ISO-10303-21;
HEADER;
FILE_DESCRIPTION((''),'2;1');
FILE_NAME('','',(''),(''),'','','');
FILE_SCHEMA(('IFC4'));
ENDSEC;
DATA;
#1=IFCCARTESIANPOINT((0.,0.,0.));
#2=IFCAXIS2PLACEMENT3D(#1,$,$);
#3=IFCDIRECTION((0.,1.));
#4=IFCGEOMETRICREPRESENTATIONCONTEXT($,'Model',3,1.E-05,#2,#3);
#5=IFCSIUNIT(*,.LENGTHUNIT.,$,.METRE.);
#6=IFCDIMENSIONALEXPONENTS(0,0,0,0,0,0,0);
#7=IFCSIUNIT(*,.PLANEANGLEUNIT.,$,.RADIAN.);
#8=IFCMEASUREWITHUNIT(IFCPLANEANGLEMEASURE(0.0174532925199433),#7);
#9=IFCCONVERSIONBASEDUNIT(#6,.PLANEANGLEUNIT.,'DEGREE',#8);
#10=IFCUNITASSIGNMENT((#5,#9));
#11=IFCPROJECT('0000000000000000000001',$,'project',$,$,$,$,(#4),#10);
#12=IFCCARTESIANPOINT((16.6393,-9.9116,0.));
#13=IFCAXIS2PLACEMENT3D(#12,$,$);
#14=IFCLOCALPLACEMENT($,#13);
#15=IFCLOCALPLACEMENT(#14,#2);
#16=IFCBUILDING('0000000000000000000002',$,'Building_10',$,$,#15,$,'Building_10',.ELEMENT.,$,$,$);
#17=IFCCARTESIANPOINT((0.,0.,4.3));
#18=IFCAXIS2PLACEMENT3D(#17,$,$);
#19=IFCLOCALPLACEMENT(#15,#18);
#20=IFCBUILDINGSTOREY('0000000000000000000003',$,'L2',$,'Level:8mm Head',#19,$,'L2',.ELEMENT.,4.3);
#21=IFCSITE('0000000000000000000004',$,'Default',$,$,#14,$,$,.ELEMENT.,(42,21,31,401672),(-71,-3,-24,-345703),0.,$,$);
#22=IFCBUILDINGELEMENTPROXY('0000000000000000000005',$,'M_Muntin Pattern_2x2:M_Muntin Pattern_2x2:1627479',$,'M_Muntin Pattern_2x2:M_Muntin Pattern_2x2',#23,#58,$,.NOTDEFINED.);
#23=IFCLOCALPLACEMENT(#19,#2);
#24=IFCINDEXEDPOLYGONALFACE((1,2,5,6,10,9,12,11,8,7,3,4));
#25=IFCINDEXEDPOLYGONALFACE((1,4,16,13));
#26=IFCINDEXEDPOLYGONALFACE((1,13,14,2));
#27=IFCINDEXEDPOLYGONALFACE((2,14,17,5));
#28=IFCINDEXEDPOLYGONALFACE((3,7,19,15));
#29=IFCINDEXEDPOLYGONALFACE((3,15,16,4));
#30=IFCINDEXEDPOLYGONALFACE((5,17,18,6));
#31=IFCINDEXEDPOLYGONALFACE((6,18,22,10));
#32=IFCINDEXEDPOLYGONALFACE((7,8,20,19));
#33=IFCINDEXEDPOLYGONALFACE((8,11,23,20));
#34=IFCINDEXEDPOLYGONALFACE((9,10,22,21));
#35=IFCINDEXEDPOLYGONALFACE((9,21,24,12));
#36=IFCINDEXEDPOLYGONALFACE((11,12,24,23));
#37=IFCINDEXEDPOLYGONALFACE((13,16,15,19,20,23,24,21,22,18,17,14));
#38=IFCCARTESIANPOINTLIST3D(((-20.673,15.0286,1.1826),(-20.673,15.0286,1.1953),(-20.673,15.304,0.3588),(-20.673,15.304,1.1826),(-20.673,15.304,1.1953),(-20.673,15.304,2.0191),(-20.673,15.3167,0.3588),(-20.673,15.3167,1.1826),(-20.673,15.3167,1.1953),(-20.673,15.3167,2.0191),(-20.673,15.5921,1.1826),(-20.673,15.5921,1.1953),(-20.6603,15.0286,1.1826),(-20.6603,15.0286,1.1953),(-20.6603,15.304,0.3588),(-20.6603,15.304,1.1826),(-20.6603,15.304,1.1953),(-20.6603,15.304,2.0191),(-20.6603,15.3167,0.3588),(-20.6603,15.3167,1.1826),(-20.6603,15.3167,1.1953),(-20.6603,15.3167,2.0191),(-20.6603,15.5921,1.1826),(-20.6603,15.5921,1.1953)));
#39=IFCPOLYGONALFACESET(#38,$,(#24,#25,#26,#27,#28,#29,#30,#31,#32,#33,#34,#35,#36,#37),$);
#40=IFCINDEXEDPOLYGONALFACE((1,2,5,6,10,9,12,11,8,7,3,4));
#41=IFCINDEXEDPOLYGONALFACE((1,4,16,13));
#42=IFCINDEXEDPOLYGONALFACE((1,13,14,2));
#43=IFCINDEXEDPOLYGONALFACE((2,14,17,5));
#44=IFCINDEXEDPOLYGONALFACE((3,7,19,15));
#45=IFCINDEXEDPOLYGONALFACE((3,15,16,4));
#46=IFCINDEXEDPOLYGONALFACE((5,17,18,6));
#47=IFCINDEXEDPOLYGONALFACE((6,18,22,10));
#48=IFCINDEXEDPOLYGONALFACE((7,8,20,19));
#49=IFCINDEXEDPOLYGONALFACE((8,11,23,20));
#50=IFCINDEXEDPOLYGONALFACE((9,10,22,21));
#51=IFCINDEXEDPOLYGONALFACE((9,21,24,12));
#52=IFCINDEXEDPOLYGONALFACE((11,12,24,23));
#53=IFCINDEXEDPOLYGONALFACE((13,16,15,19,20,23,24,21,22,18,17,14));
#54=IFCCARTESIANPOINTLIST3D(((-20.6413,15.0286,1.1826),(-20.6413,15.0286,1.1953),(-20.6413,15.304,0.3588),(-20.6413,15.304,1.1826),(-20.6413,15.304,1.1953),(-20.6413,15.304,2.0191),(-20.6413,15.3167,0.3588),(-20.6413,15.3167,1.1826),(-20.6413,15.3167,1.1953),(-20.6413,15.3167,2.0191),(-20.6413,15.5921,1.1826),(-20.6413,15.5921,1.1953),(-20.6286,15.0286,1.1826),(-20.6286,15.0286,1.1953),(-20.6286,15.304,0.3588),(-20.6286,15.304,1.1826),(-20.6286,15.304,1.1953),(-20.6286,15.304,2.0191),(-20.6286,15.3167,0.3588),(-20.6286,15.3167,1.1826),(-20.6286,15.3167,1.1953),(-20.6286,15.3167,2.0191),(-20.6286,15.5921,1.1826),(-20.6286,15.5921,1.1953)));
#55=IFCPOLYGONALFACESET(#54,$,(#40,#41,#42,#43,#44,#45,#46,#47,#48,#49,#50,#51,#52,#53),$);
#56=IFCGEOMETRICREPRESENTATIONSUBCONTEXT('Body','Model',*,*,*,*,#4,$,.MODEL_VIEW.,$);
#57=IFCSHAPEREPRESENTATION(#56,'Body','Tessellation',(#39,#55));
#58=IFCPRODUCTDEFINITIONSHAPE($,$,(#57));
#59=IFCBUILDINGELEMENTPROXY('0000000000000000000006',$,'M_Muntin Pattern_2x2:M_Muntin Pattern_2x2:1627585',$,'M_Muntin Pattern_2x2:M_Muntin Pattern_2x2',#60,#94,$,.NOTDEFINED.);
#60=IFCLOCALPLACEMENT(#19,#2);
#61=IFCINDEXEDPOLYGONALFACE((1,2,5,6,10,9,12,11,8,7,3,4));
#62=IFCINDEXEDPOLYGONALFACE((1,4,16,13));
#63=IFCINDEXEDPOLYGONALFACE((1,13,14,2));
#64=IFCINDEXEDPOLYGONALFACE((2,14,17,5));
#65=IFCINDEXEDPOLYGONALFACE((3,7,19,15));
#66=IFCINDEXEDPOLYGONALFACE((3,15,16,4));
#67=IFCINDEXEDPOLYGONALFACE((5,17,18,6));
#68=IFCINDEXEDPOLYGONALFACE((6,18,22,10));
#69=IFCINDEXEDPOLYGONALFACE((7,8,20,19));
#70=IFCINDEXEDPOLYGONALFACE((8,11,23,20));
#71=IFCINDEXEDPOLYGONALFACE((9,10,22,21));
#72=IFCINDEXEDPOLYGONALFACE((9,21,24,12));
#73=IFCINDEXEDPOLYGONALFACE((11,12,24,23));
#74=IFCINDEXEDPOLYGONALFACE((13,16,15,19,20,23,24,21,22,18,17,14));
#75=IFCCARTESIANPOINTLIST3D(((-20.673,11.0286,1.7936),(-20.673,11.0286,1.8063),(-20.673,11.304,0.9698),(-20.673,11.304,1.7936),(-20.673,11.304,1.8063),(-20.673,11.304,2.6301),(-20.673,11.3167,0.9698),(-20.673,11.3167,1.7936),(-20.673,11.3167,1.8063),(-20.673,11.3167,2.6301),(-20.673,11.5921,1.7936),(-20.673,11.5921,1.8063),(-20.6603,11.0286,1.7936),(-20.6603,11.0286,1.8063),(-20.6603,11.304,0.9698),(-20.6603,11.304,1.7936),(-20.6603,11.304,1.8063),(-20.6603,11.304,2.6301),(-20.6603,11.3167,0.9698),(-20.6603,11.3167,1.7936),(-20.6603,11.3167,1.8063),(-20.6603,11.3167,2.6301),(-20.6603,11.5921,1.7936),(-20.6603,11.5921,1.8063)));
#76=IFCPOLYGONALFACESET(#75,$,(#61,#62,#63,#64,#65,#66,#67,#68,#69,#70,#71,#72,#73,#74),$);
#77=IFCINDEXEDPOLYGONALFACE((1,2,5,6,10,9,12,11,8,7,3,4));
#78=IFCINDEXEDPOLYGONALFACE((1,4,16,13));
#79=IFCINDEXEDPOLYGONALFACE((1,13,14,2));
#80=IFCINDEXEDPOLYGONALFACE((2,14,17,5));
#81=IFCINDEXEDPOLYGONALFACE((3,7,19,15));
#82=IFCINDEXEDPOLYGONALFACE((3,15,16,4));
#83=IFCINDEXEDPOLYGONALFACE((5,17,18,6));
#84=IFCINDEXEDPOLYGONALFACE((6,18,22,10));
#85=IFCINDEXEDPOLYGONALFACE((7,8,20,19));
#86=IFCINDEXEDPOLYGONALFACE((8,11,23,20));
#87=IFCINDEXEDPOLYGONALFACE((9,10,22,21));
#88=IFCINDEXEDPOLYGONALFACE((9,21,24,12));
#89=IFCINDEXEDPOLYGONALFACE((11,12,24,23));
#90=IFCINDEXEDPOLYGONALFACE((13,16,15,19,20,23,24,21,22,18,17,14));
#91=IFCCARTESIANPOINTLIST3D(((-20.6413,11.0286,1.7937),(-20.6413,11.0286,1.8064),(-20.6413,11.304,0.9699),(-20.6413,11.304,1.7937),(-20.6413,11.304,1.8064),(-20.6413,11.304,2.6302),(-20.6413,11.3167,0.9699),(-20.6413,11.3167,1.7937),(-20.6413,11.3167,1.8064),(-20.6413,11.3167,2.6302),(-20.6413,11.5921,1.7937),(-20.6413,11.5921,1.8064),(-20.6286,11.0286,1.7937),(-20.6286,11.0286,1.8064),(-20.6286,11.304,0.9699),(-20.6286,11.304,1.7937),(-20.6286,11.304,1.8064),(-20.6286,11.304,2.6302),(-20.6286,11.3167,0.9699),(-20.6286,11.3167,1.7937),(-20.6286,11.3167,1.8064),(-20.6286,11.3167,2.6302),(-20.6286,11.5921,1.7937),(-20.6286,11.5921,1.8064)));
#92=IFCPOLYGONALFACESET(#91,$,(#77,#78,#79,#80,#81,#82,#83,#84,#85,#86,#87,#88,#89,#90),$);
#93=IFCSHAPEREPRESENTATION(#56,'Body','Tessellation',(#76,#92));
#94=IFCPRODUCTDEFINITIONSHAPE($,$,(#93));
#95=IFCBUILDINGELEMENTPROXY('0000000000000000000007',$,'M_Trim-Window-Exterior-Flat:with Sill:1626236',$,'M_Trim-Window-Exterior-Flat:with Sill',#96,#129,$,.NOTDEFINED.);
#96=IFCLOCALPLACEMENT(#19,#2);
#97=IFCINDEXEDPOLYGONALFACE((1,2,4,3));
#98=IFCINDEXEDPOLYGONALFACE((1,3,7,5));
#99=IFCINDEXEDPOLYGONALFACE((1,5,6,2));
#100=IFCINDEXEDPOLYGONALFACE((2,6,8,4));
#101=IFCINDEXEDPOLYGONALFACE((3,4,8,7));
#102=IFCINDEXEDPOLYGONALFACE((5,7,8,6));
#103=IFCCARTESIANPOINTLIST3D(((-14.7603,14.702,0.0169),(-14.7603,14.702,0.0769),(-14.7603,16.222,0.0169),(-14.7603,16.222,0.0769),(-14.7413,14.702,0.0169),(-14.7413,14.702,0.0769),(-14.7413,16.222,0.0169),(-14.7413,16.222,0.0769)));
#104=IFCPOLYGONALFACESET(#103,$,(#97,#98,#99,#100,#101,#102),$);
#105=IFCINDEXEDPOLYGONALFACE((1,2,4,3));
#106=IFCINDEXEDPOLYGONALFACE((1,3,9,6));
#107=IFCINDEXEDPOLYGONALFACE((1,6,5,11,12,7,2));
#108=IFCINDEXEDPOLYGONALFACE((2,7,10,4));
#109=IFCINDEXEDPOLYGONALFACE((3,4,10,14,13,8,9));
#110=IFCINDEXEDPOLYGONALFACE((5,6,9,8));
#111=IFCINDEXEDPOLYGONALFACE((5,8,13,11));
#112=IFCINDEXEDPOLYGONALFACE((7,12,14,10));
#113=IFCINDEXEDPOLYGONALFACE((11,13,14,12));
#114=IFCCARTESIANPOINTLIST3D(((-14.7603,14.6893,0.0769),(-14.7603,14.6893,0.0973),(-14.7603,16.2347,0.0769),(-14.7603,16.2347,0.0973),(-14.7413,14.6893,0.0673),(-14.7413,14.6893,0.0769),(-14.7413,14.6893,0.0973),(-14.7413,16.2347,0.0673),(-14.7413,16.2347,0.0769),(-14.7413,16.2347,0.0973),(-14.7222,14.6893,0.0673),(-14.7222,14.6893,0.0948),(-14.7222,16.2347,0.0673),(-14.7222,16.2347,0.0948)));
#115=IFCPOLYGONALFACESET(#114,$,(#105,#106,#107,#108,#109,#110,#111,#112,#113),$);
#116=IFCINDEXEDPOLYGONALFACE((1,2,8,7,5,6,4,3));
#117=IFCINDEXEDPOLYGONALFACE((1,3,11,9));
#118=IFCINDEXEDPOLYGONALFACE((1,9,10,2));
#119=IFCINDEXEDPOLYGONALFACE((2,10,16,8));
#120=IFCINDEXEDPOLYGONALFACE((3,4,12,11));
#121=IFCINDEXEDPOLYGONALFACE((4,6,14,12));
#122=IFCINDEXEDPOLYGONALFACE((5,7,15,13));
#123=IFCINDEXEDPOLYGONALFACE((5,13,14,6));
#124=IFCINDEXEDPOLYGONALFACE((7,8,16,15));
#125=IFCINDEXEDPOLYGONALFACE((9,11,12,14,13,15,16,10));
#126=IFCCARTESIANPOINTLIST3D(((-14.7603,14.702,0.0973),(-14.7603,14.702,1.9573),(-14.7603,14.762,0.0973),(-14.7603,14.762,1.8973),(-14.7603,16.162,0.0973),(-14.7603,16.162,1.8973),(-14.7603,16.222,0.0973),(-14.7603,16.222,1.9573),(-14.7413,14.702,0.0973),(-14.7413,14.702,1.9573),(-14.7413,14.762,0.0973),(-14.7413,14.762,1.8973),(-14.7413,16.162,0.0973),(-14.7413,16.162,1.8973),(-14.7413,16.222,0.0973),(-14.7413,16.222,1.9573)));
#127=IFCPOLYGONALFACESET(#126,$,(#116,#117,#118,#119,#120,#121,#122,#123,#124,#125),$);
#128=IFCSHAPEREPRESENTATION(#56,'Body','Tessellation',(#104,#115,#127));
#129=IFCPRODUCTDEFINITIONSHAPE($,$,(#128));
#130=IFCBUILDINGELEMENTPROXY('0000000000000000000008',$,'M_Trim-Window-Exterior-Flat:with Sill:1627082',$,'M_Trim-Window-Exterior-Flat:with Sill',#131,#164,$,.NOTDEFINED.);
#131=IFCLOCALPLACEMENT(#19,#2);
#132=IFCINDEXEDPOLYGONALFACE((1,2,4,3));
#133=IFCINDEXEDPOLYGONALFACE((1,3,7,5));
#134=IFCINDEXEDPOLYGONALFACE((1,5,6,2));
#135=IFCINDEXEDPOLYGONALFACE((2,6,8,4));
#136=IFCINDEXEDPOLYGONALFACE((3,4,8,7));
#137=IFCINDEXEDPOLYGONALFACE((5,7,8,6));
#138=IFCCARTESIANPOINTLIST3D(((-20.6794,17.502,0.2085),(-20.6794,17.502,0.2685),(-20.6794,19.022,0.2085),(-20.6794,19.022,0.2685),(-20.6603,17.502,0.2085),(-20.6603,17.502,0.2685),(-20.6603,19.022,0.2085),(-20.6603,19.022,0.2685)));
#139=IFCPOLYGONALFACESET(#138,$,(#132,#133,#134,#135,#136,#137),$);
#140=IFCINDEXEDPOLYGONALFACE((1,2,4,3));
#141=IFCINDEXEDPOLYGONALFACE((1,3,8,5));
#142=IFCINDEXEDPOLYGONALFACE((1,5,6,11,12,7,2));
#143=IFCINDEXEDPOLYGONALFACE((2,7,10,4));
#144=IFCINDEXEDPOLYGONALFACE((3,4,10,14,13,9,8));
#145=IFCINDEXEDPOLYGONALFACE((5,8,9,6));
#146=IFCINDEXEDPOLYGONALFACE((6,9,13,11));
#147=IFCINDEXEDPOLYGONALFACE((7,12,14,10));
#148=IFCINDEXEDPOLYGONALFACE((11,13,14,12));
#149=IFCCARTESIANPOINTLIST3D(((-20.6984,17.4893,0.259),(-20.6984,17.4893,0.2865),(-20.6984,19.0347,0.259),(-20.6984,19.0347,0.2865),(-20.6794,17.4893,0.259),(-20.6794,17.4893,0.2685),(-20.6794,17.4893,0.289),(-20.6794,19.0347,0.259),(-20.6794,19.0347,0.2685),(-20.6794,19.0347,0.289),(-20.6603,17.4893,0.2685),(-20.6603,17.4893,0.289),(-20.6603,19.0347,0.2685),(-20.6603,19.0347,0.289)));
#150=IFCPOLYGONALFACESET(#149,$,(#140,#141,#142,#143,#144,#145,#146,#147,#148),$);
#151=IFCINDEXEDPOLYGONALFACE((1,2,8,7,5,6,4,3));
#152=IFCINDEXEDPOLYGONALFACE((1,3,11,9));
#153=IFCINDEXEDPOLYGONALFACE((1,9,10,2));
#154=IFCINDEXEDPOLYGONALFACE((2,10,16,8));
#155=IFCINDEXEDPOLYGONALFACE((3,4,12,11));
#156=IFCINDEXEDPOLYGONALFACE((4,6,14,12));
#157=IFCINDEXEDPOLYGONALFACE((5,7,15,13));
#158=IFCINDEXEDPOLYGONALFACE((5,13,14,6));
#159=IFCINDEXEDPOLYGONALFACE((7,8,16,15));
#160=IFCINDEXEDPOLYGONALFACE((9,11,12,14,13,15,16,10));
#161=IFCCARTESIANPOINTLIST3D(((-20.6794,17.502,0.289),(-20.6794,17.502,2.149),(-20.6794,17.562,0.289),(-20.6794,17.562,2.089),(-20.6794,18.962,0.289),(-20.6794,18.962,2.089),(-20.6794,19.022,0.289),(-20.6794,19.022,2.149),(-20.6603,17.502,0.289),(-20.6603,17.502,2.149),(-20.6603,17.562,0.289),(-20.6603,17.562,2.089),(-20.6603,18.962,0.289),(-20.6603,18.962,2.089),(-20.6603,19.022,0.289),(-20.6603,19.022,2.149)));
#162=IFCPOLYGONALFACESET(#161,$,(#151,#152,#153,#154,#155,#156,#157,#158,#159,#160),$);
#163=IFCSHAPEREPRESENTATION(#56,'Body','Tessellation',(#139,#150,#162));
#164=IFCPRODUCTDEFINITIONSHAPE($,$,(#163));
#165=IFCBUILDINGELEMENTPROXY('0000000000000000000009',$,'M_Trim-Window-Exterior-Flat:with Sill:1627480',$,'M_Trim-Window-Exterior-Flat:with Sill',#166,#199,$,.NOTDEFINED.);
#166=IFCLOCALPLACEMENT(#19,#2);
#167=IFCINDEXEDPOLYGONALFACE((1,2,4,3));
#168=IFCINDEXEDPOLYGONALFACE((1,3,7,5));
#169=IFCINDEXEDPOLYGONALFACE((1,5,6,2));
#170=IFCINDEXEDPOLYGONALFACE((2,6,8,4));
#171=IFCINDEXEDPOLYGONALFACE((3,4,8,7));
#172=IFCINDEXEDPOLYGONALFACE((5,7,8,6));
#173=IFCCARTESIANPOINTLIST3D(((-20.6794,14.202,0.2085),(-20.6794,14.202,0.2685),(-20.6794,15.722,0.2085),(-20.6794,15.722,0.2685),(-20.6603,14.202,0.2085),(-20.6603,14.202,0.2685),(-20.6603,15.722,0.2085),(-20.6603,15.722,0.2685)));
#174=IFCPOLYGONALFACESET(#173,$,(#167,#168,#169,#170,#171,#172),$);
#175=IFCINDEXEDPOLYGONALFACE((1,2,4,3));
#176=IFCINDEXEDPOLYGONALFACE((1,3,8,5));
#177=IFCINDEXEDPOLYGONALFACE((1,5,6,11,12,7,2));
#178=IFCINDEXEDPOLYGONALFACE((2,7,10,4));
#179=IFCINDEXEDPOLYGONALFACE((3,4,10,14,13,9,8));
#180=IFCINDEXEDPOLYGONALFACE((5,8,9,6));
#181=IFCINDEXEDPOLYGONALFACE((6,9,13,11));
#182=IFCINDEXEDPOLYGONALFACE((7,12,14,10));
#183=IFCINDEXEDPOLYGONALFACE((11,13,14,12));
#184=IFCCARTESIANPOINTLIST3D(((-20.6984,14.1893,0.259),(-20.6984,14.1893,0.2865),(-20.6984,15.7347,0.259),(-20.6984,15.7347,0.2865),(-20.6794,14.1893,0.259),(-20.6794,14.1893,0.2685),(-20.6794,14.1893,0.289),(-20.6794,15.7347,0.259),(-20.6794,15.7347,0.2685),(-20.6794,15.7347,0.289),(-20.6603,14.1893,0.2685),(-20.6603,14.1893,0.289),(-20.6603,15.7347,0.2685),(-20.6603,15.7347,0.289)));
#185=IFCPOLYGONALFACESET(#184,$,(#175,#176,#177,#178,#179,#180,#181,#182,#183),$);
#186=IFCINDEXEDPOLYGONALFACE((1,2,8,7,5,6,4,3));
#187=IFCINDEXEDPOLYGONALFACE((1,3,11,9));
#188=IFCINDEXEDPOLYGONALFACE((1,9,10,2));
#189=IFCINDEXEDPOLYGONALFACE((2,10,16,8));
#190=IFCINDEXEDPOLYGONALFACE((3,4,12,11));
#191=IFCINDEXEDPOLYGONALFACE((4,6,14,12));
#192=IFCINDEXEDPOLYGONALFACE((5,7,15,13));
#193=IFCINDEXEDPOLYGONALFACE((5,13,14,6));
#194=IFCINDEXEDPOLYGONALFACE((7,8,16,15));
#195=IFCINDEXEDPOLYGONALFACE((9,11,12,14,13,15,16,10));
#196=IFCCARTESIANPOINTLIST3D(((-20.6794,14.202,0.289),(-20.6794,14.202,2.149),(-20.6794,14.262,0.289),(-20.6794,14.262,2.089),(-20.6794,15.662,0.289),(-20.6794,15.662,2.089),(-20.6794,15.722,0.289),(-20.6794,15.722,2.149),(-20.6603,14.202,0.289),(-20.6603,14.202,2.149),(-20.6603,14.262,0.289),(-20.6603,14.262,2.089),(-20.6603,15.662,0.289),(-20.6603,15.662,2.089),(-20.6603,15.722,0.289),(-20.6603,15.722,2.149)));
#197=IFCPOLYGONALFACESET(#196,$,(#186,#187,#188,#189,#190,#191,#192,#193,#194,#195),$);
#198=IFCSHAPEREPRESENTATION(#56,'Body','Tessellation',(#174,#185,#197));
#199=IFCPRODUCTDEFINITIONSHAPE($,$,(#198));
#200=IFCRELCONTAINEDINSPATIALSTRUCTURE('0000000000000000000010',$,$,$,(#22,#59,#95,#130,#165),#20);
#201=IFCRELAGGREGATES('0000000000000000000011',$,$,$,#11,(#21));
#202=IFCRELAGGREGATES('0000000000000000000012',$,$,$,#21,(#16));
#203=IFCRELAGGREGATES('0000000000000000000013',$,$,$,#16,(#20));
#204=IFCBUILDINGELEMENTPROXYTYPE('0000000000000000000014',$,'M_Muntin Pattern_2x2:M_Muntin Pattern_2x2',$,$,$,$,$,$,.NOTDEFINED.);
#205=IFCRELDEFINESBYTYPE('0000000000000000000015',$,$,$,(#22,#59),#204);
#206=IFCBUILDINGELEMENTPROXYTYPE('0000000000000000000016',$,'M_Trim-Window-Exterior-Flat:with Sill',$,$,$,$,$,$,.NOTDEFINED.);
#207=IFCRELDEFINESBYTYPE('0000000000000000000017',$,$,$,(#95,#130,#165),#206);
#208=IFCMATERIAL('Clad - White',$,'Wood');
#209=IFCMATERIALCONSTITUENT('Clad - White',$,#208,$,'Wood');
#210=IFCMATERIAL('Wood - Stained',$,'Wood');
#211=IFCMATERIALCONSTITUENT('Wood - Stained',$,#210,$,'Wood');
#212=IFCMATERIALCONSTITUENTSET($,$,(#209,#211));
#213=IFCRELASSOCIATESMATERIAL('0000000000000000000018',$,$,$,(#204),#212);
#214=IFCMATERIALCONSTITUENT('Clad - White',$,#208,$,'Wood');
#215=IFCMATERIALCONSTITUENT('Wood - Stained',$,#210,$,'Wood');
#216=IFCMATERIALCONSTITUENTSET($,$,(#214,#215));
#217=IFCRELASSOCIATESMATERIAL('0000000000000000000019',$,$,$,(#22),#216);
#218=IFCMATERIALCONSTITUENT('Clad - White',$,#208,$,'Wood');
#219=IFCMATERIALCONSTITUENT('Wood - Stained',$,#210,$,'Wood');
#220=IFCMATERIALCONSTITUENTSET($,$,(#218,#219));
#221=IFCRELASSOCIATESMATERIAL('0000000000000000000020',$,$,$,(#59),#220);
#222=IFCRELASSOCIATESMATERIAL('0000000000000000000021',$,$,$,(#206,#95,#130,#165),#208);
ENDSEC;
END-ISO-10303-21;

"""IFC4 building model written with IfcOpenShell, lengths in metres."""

from ifc_helpers import new_model, entity, si_unit, converted_unit, direction, frame, origin, place, context, subcontext, project, spatial, indexed_curve, outline, extrude, source, transform, mapped, material, constituent, constituent_set, type_object, type_shapes, element, save


model = new_model("IFC4")

# Units and contexts
model_context = context("Model", 3, precision=1e-05, world=origin(), true_north=direction((0.0, 1.0)))
body_context = subcontext(model_context, "Body", "Model", "MODEL_VIEW")
ifc_project = project(units=[si_unit("LENGTHUNIT", "METRE"), converted_unit("PLANEANGLEUNIT", "DEGREE", entity("IfcPlaneAngleMeasure", 0.0174532925199433), si_unit("PLANEANGLEUNIT", "RADIAN"), dimensions=[0, 0, 0, 0, 0, 0, 0])], contexts=[model_context])

# Site, building, storey
site_placement = place(None, frame((16.6393, -9.9116, 0.0)))
site = spatial("IfcSite", under=ifc_project, at=site_placement, Name="Default", CompositionType="ELEMENT", RefLatitude=(42, 21, 31, 401672), RefLongitude=(-71, -3, -24, -345703), RefElevation=0.0)
building_placement = place(site_placement, origin())
building = spatial("IfcBuilding", under=site, at=building_placement, Name="Building_10", LongName="Building_10", CompositionType="ELEMENT")
storey_placement = place(building_placement, frame((0.0, 0.0, 4.3)))
storey = spatial("IfcBuildingStorey", under=building, at=storey_placement, Name="L2", ObjectType="Level:8mm Head", LongName="L2", CompositionType="ELEMENT", Elevation=4.3)

# Building element proxies
ifc_material_1 = material(Name="Clad - White", Category="Wood")
ifc_material_2 = material(Name="Wood - Stained", Category="Wood")
ifc_constituent_1 = constituent(ifc_material_1, Name="Clad - White", Category="Wood")
ifc_constituent_2 = constituent(ifc_material_2, Name="Wood - Stained", Category="Wood")
ifc_constituent_set_1 = constituent_set(constituents=[ifc_constituent_1, ifc_constituent_2])
building_element_proxy_type_1 = type_object("IfcBuildingElementProxyType", Name="M_Muntin Pattern_2x2:M_Muntin Pattern_2x2", PredefinedType="NOTDEFINED", material=ifc_constituent_set_1)
shared_shape_1 = source(origin(), body_context, "Body", "SweptSolid", [
    extrude(outline(indexed_curve([(0.0064, -0.0064), (0.8301, -0.0064), (0.8301, 0.0063), (0.0064, 0.0063), (0.0064, 0.2817), (-0.0063, 0.2817), (-0.0063, 0.0063), (-0.8302, 0.0063), (-0.8302, -0.0064), (-0.0063, -0.0064), (-0.0063, -0.2817), (0.0064, -0.2817), (0.0064, -0.0064)], self_intersect=False)), frame((0.0, -0.0222, 0.8301), z_axis=(0.0, 1.0, 0.0), x_axis=(0.0, 0.0, 1.0)), (0.0, 0.0, 1.0), 0.0127),
    extrude(outline(indexed_curve([(0.0064, -0.0064), (0.8302, -0.0064), (0.8302, 0.0063), (0.0064, 0.0063), (0.0064, 0.2817), (-0.0063, 0.2817), (-0.0063, 0.0063), (-0.8302, 0.0063), (-0.8302, -0.0064), (-0.0063, -0.0064), (-0.0063, -0.2817), (0.0064, -0.2817), (0.0064, -0.0064)], self_intersect=False)), frame((0.0, 0.0095, 0.8302), z_axis=(0.0, 1.0, 0.0), x_axis=(0.0, 0.0, 1.0)), (0.0, 0.0, 1.0), 0.0127),
])
type_shapes(building_element_proxy_type_1, [shared_shape_1])
ifc_constituent_3 = constituent(ifc_material_1, Name="Clad - White", Category="Wood")
ifc_constituent_4 = constituent(ifc_material_2, Name="Wood - Stained", Category="Wood")
ifc_constituent_set_2 = constituent_set(constituents=[ifc_constituent_3, ifc_constituent_4])
proxy_1_placement = place(storey_placement, frame((-20.6508, 15.3104, 0.3588), z_axis=(0.0, 0.0, 1.0), x_axis=(0.0, -1.0, 0.0)))
element("IfcBuildingElementProxy", 1, at=proxy_1_placement, inside=storey, type_object=building_element_proxy_type_1, material=ifc_constituent_set_2, Name="M_Muntin Pattern_2x2:M_Muntin Pattern_2x2:1627479", ObjectType="M_Muntin Pattern_2x2:M_Muntin Pattern_2x2", PredefinedType="NOTDEFINED", context=body_context, shape_type="MappedRepresentation", body=[
    mapped(shared_shape_1, transform((0.0, 0.0, 0.0), scale=1.0)),
])
ifc_constituent_5 = constituent(ifc_material_1, Name="Clad - White", Category="Wood")
ifc_constituent_6 = constituent(ifc_material_2, Name="Wood - Stained", Category="Wood")
ifc_constituent_set_3 = constituent_set(constituents=[ifc_constituent_5, ifc_constituent_6])
proxy_2_placement = place(storey_placement, frame((-20.6508, 11.3104, 0.9699), z_axis=(0.0, 0.0, 1.0), x_axis=(0.0, -1.0, 0.0)))
element("IfcBuildingElementProxy", 2, at=proxy_2_placement, inside=storey, type_object=building_element_proxy_type_1, material=ifc_constituent_set_3, Name="M_Muntin Pattern_2x2:M_Muntin Pattern_2x2:1627585", ObjectType="M_Muntin Pattern_2x2:M_Muntin Pattern_2x2", PredefinedType="NOTDEFINED", context=body_context, shape_type="MappedRepresentation", body=[
    mapped(shared_shape_1, transform((0.0, 0.0, 0.0), scale=1.0)),
])
building_element_proxy_type_2 = type_object("IfcBuildingElementProxyType", Name="M_Trim-Window-Exterior-Flat:with Sill", PredefinedType="NOTDEFINED", material=ifc_material_1)
shared_shape_2 = source(origin(), body_context, "Body", "SweptSolid", [
    extrude(outline(indexed_curve([(-0.76, -0.03), (0.76, -0.03), (0.76, 0.03), (-0.76, 0.03), (-0.76, -0.03)], self_intersect=False)), frame((0.0, -1.8504, 0.0), z_axis=(0.0, 0.0, 1.0), x_axis=(-1.0, 0.0, 0.0)), (0.0, 0.0, 1.0), 0.0191),
    extrude(outline(indexed_curve([(-0.019, -0.0152), (0.0, -0.0152), (0.0, -0.0057), (0.019, -0.0057), (0.019, 0.0148), (0.0, 0.0148), (-0.019, 0.0123), (-0.019, -0.0152)], self_intersect=False)), frame((-0.7727, -1.8148, 0.019), z_axis=(1.0, 0.0, 0.0), x_axis=(0.0, 0.0, -1.0)), (0.0, 0.0, 1.0), 1.5454),
    extrude(outline(indexed_curve([(-0.945, -0.76), (0.915, -0.76), (0.915, -0.7), (-0.885, -0.7), (-0.885, 0.7), (0.915, 0.7), (0.915, 0.76), (-0.945, 0.76), (-0.945, -0.76)], self_intersect=False)), frame((0.0, -0.885, 0.0), z_axis=(0.0, 0.0, 1.0), x_axis=(0.0, -1.0, 0.0)), (0.0, 0.0, 1.0), 0.0191),
])
type_shapes(building_element_proxy_type_2, [shared_shape_2])
for number, where, z_axis, x_axis, name in (
    (3, (-14.7603, 15.462, 1.8973), (1.0, 0.0, 0.0), (0.0, 1.0, 0.0), "M_Trim-Window-Exterior-Flat:with Sill:1626236"),
    (4, (-20.6603, 18.262, 2.089), (-1.0, 0.0, 0.0), (0.0, -1.0, 0.0), "M_Trim-Window-Exterior-Flat:with Sill:1627082"),
    (5, (-20.6603, 14.962, 2.089), (-1.0, 0.0, 0.0), (0.0, -1.0, 0.0), "M_Trim-Window-Exterior-Flat:with Sill:1627480"),
):
    element("IfcBuildingElementProxy", number, at=place(storey_placement, frame(where, z_axis=z_axis, x_axis=x_axis)), inside=storey, type_object=building_element_proxy_type_2, material=ifc_material_1, Name=name, ObjectType="M_Trim-Window-Exterior-Flat:with Sill", PredefinedType="NOTDEFINED", context=body_context, shape_type="MappedRepresentation", body=[
        mapped(shared_shape_2, transform((0.0, 0.0, 0.0), scale=1.0)),
    ])

save(model, "model.ifc")
